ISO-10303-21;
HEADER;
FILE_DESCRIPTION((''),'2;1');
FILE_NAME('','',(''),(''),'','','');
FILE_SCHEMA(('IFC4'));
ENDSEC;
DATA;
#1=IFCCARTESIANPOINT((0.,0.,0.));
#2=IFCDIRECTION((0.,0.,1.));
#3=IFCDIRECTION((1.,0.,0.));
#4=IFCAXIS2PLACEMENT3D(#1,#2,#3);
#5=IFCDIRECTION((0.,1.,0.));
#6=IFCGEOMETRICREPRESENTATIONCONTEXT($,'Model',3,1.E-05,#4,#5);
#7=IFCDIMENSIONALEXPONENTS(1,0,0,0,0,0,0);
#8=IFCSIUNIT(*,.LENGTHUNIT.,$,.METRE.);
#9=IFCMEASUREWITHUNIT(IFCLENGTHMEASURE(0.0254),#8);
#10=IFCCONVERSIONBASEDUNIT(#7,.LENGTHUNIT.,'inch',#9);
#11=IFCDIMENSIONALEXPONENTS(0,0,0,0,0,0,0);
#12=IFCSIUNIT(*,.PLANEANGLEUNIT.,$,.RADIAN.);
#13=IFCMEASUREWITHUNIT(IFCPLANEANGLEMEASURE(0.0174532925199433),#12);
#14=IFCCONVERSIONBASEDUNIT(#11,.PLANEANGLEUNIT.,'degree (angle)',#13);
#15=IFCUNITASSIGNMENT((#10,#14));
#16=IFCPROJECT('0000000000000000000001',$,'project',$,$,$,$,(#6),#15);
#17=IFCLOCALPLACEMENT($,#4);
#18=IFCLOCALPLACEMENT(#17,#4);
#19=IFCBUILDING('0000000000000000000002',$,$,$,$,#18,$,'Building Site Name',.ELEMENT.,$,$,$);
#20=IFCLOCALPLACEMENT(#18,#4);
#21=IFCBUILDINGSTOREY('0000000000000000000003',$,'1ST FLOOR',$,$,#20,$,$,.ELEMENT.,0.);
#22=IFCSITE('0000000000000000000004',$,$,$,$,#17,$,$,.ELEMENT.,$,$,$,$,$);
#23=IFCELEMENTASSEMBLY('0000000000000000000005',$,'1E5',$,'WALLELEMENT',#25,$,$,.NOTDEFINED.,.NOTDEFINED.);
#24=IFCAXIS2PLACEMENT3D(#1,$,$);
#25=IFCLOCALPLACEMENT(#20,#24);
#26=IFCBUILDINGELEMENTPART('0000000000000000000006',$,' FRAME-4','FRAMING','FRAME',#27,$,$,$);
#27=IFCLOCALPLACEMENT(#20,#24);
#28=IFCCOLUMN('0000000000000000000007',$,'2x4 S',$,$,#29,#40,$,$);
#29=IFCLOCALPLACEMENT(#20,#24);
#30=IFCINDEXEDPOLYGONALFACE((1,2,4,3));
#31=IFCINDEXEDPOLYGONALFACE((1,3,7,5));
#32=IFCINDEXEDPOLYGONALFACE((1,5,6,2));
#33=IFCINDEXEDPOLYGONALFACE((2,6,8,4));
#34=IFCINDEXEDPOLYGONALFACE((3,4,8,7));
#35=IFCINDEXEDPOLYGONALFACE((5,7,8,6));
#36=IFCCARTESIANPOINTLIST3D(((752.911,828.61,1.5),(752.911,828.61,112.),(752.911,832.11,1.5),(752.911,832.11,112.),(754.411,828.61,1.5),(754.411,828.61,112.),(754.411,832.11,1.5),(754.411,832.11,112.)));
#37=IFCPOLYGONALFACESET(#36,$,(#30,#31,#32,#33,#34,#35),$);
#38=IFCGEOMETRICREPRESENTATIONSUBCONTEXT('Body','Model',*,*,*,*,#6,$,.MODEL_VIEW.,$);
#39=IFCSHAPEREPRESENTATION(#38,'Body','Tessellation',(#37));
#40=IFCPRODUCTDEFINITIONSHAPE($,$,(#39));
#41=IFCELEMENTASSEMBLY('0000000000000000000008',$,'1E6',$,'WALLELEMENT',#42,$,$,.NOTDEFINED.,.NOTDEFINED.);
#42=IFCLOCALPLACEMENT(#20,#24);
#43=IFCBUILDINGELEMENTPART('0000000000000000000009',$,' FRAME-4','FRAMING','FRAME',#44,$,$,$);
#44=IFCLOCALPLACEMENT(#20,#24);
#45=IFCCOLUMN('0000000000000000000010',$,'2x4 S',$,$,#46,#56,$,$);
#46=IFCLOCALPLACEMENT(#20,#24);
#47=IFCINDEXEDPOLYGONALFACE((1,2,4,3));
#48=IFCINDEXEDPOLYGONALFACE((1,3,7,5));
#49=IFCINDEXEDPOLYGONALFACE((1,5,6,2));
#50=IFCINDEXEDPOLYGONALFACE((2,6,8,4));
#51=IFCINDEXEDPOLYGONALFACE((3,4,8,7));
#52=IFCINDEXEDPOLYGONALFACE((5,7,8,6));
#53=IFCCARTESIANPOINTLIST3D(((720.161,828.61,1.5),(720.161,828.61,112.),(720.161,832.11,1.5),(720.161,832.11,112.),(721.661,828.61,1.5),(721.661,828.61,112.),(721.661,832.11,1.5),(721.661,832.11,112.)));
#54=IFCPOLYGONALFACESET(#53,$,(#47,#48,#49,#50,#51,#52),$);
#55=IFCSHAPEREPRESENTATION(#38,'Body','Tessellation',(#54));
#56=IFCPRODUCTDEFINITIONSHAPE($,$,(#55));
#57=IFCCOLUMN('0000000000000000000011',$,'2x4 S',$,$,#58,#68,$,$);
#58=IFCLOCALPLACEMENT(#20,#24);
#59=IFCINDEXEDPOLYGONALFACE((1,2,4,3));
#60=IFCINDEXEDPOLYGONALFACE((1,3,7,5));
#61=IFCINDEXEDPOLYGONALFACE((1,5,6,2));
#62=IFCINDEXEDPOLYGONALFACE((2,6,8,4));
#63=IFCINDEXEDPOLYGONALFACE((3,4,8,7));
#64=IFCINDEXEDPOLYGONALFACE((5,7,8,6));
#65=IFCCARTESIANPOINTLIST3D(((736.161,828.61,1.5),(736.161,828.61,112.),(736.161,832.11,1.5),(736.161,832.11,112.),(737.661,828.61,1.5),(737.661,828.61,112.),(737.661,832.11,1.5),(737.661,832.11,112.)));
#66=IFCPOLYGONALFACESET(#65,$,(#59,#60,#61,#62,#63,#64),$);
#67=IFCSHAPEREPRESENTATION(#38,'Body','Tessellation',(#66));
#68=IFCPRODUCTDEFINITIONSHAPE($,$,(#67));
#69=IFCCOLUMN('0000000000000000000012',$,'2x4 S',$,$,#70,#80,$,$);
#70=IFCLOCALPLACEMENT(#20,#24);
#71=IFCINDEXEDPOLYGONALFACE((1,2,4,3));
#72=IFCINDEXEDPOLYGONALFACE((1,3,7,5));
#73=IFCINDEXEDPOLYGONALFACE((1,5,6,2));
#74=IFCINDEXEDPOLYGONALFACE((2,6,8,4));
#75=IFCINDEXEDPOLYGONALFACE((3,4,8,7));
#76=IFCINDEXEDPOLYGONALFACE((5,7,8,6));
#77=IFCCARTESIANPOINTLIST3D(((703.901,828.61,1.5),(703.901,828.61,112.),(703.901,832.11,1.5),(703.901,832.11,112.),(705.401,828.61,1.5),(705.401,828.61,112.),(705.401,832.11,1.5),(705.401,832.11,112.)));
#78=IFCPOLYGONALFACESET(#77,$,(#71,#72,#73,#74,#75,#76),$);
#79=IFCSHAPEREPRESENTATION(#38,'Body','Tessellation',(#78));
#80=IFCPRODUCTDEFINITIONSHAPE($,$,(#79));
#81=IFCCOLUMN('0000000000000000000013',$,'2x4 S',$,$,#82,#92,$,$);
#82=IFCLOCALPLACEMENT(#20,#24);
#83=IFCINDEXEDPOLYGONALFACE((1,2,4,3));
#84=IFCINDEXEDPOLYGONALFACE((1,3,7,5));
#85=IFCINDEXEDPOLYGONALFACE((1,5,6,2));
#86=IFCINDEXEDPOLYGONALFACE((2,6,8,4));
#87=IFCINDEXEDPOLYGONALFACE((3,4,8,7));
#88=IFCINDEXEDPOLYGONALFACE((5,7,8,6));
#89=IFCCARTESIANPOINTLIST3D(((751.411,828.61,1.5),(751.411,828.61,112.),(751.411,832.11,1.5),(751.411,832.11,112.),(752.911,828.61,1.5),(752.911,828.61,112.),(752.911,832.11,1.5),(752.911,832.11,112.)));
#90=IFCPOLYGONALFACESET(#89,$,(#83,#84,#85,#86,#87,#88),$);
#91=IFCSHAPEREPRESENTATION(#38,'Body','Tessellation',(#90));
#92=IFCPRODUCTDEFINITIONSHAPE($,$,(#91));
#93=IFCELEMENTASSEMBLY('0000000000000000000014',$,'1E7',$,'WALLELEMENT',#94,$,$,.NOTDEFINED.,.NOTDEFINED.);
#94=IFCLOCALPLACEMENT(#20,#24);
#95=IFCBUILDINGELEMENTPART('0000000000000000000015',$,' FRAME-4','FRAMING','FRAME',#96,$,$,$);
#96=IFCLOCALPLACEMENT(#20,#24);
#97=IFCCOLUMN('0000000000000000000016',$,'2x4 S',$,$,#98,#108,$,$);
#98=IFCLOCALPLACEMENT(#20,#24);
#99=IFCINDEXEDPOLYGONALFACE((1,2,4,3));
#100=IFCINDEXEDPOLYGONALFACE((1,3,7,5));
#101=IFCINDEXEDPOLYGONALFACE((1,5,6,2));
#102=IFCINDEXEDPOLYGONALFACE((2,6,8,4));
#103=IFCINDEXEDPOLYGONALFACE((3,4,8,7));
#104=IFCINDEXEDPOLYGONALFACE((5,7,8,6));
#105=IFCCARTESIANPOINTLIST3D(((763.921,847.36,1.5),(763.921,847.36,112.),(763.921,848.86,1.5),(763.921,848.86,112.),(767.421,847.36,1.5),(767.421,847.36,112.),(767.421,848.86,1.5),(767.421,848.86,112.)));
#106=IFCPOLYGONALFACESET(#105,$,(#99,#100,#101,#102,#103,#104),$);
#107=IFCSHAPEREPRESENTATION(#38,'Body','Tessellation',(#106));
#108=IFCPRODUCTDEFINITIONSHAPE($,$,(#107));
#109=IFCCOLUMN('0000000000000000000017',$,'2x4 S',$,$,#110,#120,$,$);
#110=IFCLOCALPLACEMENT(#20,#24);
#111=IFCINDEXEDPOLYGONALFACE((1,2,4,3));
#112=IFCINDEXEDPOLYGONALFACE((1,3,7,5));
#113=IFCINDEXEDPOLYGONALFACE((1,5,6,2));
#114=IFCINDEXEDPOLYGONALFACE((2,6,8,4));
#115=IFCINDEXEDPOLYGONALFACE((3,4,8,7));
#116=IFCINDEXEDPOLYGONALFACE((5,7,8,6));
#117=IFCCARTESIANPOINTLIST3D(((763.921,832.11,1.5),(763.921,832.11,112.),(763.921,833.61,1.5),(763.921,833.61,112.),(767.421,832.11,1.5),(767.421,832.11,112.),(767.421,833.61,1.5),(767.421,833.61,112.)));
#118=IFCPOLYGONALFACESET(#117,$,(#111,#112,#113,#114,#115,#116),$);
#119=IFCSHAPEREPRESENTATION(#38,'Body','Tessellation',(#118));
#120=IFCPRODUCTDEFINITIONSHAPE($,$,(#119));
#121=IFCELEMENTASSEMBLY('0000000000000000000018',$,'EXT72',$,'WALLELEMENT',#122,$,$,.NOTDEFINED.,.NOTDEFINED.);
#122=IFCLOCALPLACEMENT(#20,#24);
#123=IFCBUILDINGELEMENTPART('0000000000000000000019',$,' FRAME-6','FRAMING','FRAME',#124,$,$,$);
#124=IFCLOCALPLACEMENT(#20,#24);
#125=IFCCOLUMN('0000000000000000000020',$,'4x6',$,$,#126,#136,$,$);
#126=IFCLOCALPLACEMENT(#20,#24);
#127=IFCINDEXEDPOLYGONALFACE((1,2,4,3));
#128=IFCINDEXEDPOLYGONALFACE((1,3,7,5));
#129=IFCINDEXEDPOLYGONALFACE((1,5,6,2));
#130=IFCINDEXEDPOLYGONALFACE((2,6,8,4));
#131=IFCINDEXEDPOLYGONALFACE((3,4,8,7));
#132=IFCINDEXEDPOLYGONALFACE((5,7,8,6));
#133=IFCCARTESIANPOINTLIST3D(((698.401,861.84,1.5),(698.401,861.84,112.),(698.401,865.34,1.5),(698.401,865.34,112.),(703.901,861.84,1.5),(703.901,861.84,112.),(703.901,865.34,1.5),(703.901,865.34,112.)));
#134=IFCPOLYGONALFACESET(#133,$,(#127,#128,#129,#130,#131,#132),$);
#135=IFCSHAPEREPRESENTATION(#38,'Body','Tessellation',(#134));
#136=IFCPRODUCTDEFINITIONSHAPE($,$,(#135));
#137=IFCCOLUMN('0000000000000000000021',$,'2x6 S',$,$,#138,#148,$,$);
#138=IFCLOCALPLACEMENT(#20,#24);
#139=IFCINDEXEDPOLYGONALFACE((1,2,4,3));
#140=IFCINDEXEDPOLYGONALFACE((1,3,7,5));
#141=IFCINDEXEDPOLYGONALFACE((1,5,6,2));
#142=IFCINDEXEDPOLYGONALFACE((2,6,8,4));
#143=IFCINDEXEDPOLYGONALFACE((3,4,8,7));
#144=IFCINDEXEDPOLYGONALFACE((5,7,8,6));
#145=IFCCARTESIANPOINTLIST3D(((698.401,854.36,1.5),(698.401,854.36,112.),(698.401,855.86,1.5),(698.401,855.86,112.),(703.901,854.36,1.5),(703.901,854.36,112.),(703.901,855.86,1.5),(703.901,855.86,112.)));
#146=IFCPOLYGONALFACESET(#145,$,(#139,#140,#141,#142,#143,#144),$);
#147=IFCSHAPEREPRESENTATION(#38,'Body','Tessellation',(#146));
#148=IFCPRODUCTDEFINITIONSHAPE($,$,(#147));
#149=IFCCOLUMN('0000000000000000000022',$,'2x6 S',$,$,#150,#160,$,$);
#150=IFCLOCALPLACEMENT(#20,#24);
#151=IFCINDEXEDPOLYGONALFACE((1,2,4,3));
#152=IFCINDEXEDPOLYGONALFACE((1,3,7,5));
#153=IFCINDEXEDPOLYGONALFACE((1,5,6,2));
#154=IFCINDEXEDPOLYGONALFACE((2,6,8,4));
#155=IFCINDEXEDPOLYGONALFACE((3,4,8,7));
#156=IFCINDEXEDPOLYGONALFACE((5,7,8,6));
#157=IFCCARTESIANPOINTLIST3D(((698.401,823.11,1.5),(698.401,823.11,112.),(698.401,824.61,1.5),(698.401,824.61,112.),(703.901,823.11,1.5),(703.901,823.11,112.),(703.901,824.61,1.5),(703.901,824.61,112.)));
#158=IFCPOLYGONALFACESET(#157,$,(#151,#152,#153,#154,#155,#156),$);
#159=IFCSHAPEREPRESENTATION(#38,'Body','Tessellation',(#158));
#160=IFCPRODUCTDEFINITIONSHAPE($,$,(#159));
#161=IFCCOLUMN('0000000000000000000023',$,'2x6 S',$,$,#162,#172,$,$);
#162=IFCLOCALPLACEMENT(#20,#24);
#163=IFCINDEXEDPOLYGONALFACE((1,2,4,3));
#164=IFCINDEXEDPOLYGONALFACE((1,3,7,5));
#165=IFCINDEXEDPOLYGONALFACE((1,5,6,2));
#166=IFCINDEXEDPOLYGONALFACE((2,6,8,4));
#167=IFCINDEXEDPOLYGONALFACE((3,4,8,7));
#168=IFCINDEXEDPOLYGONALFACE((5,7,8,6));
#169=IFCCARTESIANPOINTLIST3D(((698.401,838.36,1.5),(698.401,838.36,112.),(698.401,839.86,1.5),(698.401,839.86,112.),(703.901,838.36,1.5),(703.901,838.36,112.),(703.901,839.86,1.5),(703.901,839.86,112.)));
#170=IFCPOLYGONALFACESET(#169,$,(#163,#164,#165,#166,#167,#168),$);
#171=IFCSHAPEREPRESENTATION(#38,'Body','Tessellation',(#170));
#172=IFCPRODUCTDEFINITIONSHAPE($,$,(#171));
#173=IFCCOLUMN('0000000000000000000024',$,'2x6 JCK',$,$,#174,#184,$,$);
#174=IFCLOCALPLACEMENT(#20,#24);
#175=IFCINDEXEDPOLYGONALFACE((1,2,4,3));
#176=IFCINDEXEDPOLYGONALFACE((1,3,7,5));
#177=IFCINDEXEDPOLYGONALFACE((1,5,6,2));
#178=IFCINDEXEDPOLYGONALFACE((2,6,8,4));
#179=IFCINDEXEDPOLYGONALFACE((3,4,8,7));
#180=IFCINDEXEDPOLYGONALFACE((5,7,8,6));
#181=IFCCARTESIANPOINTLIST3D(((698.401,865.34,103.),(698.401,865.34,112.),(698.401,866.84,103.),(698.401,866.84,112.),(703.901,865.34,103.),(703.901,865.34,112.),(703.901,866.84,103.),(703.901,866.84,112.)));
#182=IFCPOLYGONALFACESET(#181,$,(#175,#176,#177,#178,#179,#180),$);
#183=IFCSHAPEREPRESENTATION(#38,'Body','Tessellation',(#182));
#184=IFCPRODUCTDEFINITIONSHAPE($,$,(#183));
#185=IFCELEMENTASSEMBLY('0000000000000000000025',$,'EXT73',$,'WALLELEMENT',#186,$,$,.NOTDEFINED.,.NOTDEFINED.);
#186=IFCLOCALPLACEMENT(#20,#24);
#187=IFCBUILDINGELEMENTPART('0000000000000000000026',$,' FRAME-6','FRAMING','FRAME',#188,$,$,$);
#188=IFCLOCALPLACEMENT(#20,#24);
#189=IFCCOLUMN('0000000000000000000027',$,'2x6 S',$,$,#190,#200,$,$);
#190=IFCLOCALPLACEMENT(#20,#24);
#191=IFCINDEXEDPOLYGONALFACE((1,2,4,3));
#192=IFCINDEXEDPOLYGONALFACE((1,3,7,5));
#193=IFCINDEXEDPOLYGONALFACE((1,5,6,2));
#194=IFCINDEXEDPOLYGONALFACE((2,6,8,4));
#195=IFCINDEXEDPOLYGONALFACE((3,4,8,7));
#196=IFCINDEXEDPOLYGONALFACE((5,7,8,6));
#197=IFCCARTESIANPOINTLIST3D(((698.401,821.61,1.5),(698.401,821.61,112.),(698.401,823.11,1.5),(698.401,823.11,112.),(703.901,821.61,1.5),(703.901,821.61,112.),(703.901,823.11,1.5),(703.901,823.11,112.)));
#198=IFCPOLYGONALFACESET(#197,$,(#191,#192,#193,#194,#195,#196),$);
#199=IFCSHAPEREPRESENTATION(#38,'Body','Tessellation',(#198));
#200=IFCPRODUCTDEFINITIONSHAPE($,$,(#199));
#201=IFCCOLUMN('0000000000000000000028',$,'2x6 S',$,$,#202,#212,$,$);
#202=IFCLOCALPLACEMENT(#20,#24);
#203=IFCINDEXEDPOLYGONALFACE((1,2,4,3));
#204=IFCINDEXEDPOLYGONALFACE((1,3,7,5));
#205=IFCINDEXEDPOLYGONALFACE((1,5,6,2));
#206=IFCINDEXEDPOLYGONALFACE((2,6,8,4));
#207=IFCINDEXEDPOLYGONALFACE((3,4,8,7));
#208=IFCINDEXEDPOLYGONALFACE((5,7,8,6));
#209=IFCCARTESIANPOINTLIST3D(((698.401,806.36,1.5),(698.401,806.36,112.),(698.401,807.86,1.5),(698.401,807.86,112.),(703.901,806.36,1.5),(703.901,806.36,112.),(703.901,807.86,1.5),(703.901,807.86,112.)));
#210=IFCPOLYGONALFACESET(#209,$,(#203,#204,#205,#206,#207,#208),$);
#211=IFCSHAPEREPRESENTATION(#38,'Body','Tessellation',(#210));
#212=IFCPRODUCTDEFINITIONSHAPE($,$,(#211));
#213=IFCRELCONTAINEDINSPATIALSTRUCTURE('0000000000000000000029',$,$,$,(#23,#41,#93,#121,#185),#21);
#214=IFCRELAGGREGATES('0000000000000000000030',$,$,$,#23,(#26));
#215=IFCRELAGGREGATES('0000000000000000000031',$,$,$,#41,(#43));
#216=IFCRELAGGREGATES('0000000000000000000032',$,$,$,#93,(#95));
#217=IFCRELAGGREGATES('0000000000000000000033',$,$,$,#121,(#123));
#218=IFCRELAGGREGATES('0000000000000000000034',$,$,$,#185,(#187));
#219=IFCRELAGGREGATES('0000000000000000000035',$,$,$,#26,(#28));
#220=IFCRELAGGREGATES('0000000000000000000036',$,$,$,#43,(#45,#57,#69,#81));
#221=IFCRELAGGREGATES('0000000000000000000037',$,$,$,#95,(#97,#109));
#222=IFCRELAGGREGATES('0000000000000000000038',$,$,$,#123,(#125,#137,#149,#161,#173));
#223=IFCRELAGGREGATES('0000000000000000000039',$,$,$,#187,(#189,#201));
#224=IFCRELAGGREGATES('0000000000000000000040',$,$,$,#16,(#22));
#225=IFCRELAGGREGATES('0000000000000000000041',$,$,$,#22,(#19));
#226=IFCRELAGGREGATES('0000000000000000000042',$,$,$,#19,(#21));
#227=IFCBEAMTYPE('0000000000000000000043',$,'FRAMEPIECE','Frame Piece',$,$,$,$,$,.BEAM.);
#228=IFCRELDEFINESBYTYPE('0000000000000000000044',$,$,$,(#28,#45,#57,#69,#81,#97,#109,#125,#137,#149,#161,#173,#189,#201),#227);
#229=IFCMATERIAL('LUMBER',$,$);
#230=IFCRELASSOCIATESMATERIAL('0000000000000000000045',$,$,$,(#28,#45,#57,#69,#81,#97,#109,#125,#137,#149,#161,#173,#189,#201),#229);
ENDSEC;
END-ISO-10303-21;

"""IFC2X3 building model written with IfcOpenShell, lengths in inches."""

from ifc_helpers import new_model, entity, si_unit, converted_unit, direction, frame, frame_2d, origin_with_axes, place, context, subcontext, project, spatial, polyline, segment, composite_curve, rectangle, outline, extrude, material, type_object, element, aggregate, save


model = new_model("IFC2X3")

# Units and contexts
model_context = context("Model", 3, precision=1e-05, world=origin_with_axes(), true_north=direction((0.0, 1.0, 0.0)))
body_context = subcontext(model_context, "Body", "Model", "MODEL_VIEW")
ifc_project = project(units=[converted_unit("LENGTHUNIT", "inch", entity("IfcLengthMeasure", 0.0254), si_unit("LENGTHUNIT", "METRE"), dimensions=[1, 0, 0, 0, 0, 0, 0]), converted_unit("PLANEANGLEUNIT", "degree (angle)", entity("IfcPlaneAngleMeasure", 0.0174532925199433), si_unit("PLANEANGLEUNIT", "RADIAN"), dimensions=[0, 0, 0, 0, 0, 0, 0])], contexts=[model_context])

# Site, building, storey
site_placement = place(None, origin_with_axes())
site = spatial("IfcSite", under=ifc_project, at=site_placement, CompositionType="ELEMENT")
building_placement = place(site_placement, origin_with_axes())
building = spatial("IfcBuilding", under=site, at=building_placement, LongName="Building Site Name", CompositionType="ELEMENT")
storey_placement = place(building_placement, origin_with_axes())
storey = spatial("IfcBuildingStorey", under=building, at=storey_placement, Name="1ST FLOOR", CompositionType="ELEMENT", Elevation=0.0)

# Element assembly, building element part, column
assembly_1_placement = place(storey_placement, origin_with_axes())
assembly_1 = element("IfcElementAssembly", 1, at=assembly_1_placement, inside=storey, Name="1E5", ObjectType="WALLELEMENT", AssemblyPlace="NOTDEFINED", PredefinedType="NOTDEFINED")
building_element_part_1 = element("IfcBuildingElementPart", 2, Name=" FRAME-4", Description="FRAMING", ObjectType="FRAME")
aggregate(assembly_1, [building_element_part_1])
ifc_material_1 = material(Name="LUMBER")
beam_type = type_object("IfcBeamType", Name="FRAMEPIECE", Description="Frame Piece", PredefinedType="BEAM")
column_1_placement = place(assembly_1_placement, frame((753.661, 830.36, 1.5), z_axis=(0.0, 0.0, 1.0), x_axis=(1.0, 0.0, 0.0)))
column_1 = element("IfcColumn", 3, at=column_1_placement, type_object=beam_type, material=ifc_material_1, Name="2x4 S", context=body_context, shape_type="SweptSolid", body=[
    extrude(rectangle(XDim=1.5, YDim=3.5, at=frame_2d((0.0, 0.0), x_axis=(-1.0, 0.0))), frame((0.0, 0.0, 0.0), z_axis=(0.0, 0.0, 1.0), x_axis=(1.0, 0.0, 0.0)), (0.0, 0.0, 1.0), 110.5),
])

# Element assemblies, building element parts, columns
assembly_2_placement = place(storey_placement, origin_with_axes())
assembly_2 = element("IfcElementAssembly", 4, at=assembly_2_placement, inside=storey, Name="1E6", ObjectType="WALLELEMENT", AssemblyPlace="NOTDEFINED", PredefinedType="NOTDEFINED")
building_element_part_2 = element("IfcBuildingElementPart", 5, Name=" FRAME-4", Description="FRAMING", ObjectType="FRAME")
aggregate(assembly_2, [building_element_part_2])
column_2_placement = place(assembly_2_placement, frame((720.911, 830.36, 112.0), z_axis=(0.0, 0.0, -1.0), x_axis=(-1.0, 0.0, 0.0)))
column_2 = element("IfcColumn", 6, at=column_2_placement, type_object=beam_type, material=ifc_material_1, Name="2x4 S", context=body_context, shape_type="SweptSolid", body=[
    extrude(rectangle(XDim=1.5, YDim=3.5, at=frame_2d((0.0, 0.0), x_axis=(-1.0, 0.0))), origin_with_axes(), (0.0, 0.0, 1.0), 110.5),
])
column_3_placement = place(assembly_2_placement, frame((736.911, 830.36, 112.0), z_axis=(0.0, 0.0, -1.0), x_axis=(-1.0, 0.0, 0.0)))
column_3 = element("IfcColumn", 7, at=column_3_placement, type_object=beam_type, material=ifc_material_1, Name="2x4 S", context=body_context, shape_type="SweptSolid", body=[
    extrude(rectangle(XDim=1.5, YDim=3.5, at=frame_2d((0.0, 0.0), x_axis=(-1.0, 0.0))), origin_with_axes(), (0.0, 0.0, 1.0), 110.5),
])
column_4_placement = place(assembly_2_placement, frame((704.651, 830.36, 1.5), z_axis=(0.0, 0.0, 1.0), x_axis=(1.0, 0.0, 0.0)))
column_4 = element("IfcColumn", 8, at=column_4_placement, type_object=beam_type, material=ifc_material_1, Name="2x4 S", context=body_context, shape_type="SweptSolid", body=[
    extrude(rectangle(XDim=1.5, YDim=3.5, at=frame_2d((0.0, 0.0), x_axis=(-1.0, 0.0))), frame((0.0, 0.0, 0.0), z_axis=(0.0, 0.0, 1.0), x_axis=(1.0, 0.0, 0.0)), (0.0, 0.0, 1.0), 110.5),
])
column_5_placement = place(assembly_2_placement, frame((752.161, 830.36, 112.0), z_axis=(0.0, 0.0, -1.0), x_axis=(-1.0, 0.0, 0.0)))
column_5 = element("IfcColumn", 9, at=column_5_placement, type_object=beam_type, material=ifc_material_1, Name="2x4 S", context=body_context, shape_type="SweptSolid", body=[
    extrude(rectangle(XDim=1.5, YDim=3.5, at=frame_2d((0.0, 0.0), x_axis=(-1.0, 0.0))), origin_with_axes(), (0.0, 0.0, 1.0), 110.5),
])
assembly_3_placement = place(storey_placement, origin_with_axes())
assembly_3 = element("IfcElementAssembly", 10, at=assembly_3_placement, inside=storey, Name="1E7", ObjectType="WALLELEMENT", AssemblyPlace="NOTDEFINED", PredefinedType="NOTDEFINED")
building_element_part_3 = element("IfcBuildingElementPart", 11, Name=" FRAME-4", Description="FRAMING", ObjectType="FRAME")
aggregate(assembly_3, [building_element_part_3])
column_6_placement = place(assembly_3_placement, frame((765.671, 848.11, 112.0), z_axis=(0.0, 0.0, -1.0), x_axis=(0.0, 1.0, 0.0)))
column_6 = element("IfcColumn", 12, at=column_6_placement, type_object=beam_type, material=ifc_material_1, Name="2x4 S", context=body_context, shape_type="SweptSolid", body=[
    extrude(rectangle(XDim=1.5, YDim=3.5, at=frame_2d((0.0, 0.0), x_axis=(-1.0, 0.0))), origin_with_axes(), (0.0, 0.0, 1.0), 110.5),
])
column_7_placement = place(assembly_3_placement, frame((765.671, 832.86, 112.0), z_axis=(0.0, 0.0, -1.0), x_axis=(0.0, 1.0, 0.0)))
column_7 = element("IfcColumn", 13, at=column_7_placement, type_object=beam_type, material=ifc_material_1, Name="2x4 S", context=body_context, shape_type="SweptSolid", body=[
    extrude(rectangle(XDim=1.5, YDim=3.5, at=frame_2d((0.0, 0.0), x_axis=(-1.0, 0.0))), origin_with_axes(), (0.0, 0.0, 1.0), 110.5),
])
assembly_4_placement = place(storey_placement, origin_with_axes())
assembly_4 = element("IfcElementAssembly", 14, at=assembly_4_placement, inside=storey, Name="EXT72", ObjectType="WALLELEMENT", AssemblyPlace="NOTDEFINED", PredefinedType="NOTDEFINED")
building_element_part_4 = element("IfcBuildingElementPart", 15, Name=" FRAME-6", Description="FRAMING", ObjectType="FRAME")
aggregate(assembly_4, [building_element_part_4])
column_8_placement = place(assembly_4_placement, frame((701.151, 863.59, 1.5), z_axis=(0.0, 0.0, 1.0), x_axis=(0.0, 1.0, 0.0)))
column_8 = element("IfcColumn", 16, at=column_8_placement, type_object=beam_type, material=ifc_material_1, Name="4x6", context=body_context, shape_type="SweptSolid", body=[
    extrude(outline(composite_curve([segment(polyline([(-1.75, -2.75), (-1.75, 2.75), (1.75, 2.75), (1.75, -2.75), (-1.75, -2.75)]), True, "CONTINUOUS")], self_intersect=False)), origin_with_axes(), (0.0, 0.0, 1.0), 110.5),
])
column_9_placement = place(assembly_4_placement, frame((701.151, 855.11, 112.0), z_axis=(0.0, 0.0, -1.0), x_axis=(0.0, -1.0, 0.0)))
column_9 = element("IfcColumn", 17, at=column_9_placement, type_object=beam_type, material=ifc_material_1, Name="2x6 S", context=body_context, shape_type="SweptSolid", body=[
    extrude(rectangle(XDim=1.5, YDim=5.5, at=frame_2d((0.0, 0.0), x_axis=(-1.0, 0.0))), origin_with_axes(), (0.0, 0.0, 1.0), 110.5),
])
column_10_placement = place(assembly_4_placement, frame((701.151, 823.86, 1.5), z_axis=(0.0, 0.0, 1.0), x_axis=(0.0, 1.0, 0.0)))
column_10 = element("IfcColumn", 18, at=column_10_placement, type_object=beam_type, material=ifc_material_1, Name="2x6 S", context=body_context, shape_type="SweptSolid", body=[
    extrude(rectangle(XDim=1.5, YDim=5.5, at=frame_2d((0.0, 0.0), x_axis=(-1.0, 0.0))), frame((0.0, 0.0, 0.0), z_axis=(0.0, 0.0, 1.0), x_axis=(1.0, 0.0, 0.0)), (0.0, 0.0, 1.0), 110.5),
])
column_11_placement = place(assembly_4_placement, frame((701.151, 839.11, 112.0), z_axis=(0.0, 0.0, -1.0), x_axis=(0.0, -1.0, 0.0)))
column_11 = element("IfcColumn", 19, at=column_11_placement, type_object=beam_type, material=ifc_material_1, Name="2x6 S", context=body_context, shape_type="SweptSolid", body=[
    extrude(rectangle(XDim=1.5, YDim=5.5, at=frame_2d((0.0, 0.0), x_axis=(-1.0, 0.0))), origin_with_axes(), (0.0, 0.0, 1.0), 110.5),
])
column_12_placement = place(assembly_4_placement, frame((701.151, 866.09, 103.0), z_axis=(0.0, 0.0, 1.0), x_axis=(0.0, 1.0, 0.0)))
column_12 = element("IfcColumn", 20, at=column_12_placement, type_object=beam_type, material=ifc_material_1, Name="2x6 JCK", context=body_context, shape_type="SweptSolid", body=[
    extrude(rectangle(XDim=1.5, YDim=5.5, at=frame_2d((0.0, 0.0), x_axis=(-1.0, 0.0))), origin_with_axes(), (0.0, 0.0, 1.0), 9.0),
])
assembly_5_placement = place(storey_placement, origin_with_axes())
assembly_5 = element("IfcElementAssembly", 21, at=assembly_5_placement, inside=storey, Name="EXT73", ObjectType="WALLELEMENT", AssemblyPlace="NOTDEFINED", PredefinedType="NOTDEFINED")
building_element_part_5 = element("IfcBuildingElementPart", 22, Name=" FRAME-6", Description="FRAMING", ObjectType="FRAME")
aggregate(assembly_5, [building_element_part_5])
column_13_placement = place(assembly_5_placement, frame((701.151, 822.36, 112.0), z_axis=(0.0, 0.0, -1.0), x_axis=(0.0, -1.0, 0.0)))
column_13 = element("IfcColumn", 23, at=column_13_placement, type_object=beam_type, material=ifc_material_1, Name="2x6 S", context=body_context, shape_type="SweptSolid", body=[
    extrude(rectangle(XDim=1.5, YDim=5.5, at=frame_2d((0.0, 0.0), x_axis=(-1.0, 0.0))), origin_with_axes(), (0.0, 0.0, 1.0), 110.5),
])
column_14_placement = place(assembly_5_placement, frame((701.151, 807.11, 112.0), z_axis=(0.0, 0.0, -1.0), x_axis=(0.0, -1.0, 0.0)))
column_14 = element("IfcColumn", 24, at=column_14_placement, type_object=beam_type, material=ifc_material_1, Name="2x6 S", context=body_context, shape_type="SweptSolid", body=[
    extrude(rectangle(XDim=1.5, YDim=5.5, at=frame_2d((0.0, 0.0), x_axis=(-1.0, 0.0))), origin_with_axes(), (0.0, 0.0, 1.0), 110.5),
])

aggregate(building_element_part_1, [column_1])
aggregate(building_element_part_2, [column_2, column_3, column_4, column_5])
aggregate(building_element_part_3, [column_6, column_7])
aggregate(building_element_part_4, [column_8, column_9, column_10, column_11, column_12])
aggregate(building_element_part_5, [column_13, column_14])

save(model, "model.ifc")
